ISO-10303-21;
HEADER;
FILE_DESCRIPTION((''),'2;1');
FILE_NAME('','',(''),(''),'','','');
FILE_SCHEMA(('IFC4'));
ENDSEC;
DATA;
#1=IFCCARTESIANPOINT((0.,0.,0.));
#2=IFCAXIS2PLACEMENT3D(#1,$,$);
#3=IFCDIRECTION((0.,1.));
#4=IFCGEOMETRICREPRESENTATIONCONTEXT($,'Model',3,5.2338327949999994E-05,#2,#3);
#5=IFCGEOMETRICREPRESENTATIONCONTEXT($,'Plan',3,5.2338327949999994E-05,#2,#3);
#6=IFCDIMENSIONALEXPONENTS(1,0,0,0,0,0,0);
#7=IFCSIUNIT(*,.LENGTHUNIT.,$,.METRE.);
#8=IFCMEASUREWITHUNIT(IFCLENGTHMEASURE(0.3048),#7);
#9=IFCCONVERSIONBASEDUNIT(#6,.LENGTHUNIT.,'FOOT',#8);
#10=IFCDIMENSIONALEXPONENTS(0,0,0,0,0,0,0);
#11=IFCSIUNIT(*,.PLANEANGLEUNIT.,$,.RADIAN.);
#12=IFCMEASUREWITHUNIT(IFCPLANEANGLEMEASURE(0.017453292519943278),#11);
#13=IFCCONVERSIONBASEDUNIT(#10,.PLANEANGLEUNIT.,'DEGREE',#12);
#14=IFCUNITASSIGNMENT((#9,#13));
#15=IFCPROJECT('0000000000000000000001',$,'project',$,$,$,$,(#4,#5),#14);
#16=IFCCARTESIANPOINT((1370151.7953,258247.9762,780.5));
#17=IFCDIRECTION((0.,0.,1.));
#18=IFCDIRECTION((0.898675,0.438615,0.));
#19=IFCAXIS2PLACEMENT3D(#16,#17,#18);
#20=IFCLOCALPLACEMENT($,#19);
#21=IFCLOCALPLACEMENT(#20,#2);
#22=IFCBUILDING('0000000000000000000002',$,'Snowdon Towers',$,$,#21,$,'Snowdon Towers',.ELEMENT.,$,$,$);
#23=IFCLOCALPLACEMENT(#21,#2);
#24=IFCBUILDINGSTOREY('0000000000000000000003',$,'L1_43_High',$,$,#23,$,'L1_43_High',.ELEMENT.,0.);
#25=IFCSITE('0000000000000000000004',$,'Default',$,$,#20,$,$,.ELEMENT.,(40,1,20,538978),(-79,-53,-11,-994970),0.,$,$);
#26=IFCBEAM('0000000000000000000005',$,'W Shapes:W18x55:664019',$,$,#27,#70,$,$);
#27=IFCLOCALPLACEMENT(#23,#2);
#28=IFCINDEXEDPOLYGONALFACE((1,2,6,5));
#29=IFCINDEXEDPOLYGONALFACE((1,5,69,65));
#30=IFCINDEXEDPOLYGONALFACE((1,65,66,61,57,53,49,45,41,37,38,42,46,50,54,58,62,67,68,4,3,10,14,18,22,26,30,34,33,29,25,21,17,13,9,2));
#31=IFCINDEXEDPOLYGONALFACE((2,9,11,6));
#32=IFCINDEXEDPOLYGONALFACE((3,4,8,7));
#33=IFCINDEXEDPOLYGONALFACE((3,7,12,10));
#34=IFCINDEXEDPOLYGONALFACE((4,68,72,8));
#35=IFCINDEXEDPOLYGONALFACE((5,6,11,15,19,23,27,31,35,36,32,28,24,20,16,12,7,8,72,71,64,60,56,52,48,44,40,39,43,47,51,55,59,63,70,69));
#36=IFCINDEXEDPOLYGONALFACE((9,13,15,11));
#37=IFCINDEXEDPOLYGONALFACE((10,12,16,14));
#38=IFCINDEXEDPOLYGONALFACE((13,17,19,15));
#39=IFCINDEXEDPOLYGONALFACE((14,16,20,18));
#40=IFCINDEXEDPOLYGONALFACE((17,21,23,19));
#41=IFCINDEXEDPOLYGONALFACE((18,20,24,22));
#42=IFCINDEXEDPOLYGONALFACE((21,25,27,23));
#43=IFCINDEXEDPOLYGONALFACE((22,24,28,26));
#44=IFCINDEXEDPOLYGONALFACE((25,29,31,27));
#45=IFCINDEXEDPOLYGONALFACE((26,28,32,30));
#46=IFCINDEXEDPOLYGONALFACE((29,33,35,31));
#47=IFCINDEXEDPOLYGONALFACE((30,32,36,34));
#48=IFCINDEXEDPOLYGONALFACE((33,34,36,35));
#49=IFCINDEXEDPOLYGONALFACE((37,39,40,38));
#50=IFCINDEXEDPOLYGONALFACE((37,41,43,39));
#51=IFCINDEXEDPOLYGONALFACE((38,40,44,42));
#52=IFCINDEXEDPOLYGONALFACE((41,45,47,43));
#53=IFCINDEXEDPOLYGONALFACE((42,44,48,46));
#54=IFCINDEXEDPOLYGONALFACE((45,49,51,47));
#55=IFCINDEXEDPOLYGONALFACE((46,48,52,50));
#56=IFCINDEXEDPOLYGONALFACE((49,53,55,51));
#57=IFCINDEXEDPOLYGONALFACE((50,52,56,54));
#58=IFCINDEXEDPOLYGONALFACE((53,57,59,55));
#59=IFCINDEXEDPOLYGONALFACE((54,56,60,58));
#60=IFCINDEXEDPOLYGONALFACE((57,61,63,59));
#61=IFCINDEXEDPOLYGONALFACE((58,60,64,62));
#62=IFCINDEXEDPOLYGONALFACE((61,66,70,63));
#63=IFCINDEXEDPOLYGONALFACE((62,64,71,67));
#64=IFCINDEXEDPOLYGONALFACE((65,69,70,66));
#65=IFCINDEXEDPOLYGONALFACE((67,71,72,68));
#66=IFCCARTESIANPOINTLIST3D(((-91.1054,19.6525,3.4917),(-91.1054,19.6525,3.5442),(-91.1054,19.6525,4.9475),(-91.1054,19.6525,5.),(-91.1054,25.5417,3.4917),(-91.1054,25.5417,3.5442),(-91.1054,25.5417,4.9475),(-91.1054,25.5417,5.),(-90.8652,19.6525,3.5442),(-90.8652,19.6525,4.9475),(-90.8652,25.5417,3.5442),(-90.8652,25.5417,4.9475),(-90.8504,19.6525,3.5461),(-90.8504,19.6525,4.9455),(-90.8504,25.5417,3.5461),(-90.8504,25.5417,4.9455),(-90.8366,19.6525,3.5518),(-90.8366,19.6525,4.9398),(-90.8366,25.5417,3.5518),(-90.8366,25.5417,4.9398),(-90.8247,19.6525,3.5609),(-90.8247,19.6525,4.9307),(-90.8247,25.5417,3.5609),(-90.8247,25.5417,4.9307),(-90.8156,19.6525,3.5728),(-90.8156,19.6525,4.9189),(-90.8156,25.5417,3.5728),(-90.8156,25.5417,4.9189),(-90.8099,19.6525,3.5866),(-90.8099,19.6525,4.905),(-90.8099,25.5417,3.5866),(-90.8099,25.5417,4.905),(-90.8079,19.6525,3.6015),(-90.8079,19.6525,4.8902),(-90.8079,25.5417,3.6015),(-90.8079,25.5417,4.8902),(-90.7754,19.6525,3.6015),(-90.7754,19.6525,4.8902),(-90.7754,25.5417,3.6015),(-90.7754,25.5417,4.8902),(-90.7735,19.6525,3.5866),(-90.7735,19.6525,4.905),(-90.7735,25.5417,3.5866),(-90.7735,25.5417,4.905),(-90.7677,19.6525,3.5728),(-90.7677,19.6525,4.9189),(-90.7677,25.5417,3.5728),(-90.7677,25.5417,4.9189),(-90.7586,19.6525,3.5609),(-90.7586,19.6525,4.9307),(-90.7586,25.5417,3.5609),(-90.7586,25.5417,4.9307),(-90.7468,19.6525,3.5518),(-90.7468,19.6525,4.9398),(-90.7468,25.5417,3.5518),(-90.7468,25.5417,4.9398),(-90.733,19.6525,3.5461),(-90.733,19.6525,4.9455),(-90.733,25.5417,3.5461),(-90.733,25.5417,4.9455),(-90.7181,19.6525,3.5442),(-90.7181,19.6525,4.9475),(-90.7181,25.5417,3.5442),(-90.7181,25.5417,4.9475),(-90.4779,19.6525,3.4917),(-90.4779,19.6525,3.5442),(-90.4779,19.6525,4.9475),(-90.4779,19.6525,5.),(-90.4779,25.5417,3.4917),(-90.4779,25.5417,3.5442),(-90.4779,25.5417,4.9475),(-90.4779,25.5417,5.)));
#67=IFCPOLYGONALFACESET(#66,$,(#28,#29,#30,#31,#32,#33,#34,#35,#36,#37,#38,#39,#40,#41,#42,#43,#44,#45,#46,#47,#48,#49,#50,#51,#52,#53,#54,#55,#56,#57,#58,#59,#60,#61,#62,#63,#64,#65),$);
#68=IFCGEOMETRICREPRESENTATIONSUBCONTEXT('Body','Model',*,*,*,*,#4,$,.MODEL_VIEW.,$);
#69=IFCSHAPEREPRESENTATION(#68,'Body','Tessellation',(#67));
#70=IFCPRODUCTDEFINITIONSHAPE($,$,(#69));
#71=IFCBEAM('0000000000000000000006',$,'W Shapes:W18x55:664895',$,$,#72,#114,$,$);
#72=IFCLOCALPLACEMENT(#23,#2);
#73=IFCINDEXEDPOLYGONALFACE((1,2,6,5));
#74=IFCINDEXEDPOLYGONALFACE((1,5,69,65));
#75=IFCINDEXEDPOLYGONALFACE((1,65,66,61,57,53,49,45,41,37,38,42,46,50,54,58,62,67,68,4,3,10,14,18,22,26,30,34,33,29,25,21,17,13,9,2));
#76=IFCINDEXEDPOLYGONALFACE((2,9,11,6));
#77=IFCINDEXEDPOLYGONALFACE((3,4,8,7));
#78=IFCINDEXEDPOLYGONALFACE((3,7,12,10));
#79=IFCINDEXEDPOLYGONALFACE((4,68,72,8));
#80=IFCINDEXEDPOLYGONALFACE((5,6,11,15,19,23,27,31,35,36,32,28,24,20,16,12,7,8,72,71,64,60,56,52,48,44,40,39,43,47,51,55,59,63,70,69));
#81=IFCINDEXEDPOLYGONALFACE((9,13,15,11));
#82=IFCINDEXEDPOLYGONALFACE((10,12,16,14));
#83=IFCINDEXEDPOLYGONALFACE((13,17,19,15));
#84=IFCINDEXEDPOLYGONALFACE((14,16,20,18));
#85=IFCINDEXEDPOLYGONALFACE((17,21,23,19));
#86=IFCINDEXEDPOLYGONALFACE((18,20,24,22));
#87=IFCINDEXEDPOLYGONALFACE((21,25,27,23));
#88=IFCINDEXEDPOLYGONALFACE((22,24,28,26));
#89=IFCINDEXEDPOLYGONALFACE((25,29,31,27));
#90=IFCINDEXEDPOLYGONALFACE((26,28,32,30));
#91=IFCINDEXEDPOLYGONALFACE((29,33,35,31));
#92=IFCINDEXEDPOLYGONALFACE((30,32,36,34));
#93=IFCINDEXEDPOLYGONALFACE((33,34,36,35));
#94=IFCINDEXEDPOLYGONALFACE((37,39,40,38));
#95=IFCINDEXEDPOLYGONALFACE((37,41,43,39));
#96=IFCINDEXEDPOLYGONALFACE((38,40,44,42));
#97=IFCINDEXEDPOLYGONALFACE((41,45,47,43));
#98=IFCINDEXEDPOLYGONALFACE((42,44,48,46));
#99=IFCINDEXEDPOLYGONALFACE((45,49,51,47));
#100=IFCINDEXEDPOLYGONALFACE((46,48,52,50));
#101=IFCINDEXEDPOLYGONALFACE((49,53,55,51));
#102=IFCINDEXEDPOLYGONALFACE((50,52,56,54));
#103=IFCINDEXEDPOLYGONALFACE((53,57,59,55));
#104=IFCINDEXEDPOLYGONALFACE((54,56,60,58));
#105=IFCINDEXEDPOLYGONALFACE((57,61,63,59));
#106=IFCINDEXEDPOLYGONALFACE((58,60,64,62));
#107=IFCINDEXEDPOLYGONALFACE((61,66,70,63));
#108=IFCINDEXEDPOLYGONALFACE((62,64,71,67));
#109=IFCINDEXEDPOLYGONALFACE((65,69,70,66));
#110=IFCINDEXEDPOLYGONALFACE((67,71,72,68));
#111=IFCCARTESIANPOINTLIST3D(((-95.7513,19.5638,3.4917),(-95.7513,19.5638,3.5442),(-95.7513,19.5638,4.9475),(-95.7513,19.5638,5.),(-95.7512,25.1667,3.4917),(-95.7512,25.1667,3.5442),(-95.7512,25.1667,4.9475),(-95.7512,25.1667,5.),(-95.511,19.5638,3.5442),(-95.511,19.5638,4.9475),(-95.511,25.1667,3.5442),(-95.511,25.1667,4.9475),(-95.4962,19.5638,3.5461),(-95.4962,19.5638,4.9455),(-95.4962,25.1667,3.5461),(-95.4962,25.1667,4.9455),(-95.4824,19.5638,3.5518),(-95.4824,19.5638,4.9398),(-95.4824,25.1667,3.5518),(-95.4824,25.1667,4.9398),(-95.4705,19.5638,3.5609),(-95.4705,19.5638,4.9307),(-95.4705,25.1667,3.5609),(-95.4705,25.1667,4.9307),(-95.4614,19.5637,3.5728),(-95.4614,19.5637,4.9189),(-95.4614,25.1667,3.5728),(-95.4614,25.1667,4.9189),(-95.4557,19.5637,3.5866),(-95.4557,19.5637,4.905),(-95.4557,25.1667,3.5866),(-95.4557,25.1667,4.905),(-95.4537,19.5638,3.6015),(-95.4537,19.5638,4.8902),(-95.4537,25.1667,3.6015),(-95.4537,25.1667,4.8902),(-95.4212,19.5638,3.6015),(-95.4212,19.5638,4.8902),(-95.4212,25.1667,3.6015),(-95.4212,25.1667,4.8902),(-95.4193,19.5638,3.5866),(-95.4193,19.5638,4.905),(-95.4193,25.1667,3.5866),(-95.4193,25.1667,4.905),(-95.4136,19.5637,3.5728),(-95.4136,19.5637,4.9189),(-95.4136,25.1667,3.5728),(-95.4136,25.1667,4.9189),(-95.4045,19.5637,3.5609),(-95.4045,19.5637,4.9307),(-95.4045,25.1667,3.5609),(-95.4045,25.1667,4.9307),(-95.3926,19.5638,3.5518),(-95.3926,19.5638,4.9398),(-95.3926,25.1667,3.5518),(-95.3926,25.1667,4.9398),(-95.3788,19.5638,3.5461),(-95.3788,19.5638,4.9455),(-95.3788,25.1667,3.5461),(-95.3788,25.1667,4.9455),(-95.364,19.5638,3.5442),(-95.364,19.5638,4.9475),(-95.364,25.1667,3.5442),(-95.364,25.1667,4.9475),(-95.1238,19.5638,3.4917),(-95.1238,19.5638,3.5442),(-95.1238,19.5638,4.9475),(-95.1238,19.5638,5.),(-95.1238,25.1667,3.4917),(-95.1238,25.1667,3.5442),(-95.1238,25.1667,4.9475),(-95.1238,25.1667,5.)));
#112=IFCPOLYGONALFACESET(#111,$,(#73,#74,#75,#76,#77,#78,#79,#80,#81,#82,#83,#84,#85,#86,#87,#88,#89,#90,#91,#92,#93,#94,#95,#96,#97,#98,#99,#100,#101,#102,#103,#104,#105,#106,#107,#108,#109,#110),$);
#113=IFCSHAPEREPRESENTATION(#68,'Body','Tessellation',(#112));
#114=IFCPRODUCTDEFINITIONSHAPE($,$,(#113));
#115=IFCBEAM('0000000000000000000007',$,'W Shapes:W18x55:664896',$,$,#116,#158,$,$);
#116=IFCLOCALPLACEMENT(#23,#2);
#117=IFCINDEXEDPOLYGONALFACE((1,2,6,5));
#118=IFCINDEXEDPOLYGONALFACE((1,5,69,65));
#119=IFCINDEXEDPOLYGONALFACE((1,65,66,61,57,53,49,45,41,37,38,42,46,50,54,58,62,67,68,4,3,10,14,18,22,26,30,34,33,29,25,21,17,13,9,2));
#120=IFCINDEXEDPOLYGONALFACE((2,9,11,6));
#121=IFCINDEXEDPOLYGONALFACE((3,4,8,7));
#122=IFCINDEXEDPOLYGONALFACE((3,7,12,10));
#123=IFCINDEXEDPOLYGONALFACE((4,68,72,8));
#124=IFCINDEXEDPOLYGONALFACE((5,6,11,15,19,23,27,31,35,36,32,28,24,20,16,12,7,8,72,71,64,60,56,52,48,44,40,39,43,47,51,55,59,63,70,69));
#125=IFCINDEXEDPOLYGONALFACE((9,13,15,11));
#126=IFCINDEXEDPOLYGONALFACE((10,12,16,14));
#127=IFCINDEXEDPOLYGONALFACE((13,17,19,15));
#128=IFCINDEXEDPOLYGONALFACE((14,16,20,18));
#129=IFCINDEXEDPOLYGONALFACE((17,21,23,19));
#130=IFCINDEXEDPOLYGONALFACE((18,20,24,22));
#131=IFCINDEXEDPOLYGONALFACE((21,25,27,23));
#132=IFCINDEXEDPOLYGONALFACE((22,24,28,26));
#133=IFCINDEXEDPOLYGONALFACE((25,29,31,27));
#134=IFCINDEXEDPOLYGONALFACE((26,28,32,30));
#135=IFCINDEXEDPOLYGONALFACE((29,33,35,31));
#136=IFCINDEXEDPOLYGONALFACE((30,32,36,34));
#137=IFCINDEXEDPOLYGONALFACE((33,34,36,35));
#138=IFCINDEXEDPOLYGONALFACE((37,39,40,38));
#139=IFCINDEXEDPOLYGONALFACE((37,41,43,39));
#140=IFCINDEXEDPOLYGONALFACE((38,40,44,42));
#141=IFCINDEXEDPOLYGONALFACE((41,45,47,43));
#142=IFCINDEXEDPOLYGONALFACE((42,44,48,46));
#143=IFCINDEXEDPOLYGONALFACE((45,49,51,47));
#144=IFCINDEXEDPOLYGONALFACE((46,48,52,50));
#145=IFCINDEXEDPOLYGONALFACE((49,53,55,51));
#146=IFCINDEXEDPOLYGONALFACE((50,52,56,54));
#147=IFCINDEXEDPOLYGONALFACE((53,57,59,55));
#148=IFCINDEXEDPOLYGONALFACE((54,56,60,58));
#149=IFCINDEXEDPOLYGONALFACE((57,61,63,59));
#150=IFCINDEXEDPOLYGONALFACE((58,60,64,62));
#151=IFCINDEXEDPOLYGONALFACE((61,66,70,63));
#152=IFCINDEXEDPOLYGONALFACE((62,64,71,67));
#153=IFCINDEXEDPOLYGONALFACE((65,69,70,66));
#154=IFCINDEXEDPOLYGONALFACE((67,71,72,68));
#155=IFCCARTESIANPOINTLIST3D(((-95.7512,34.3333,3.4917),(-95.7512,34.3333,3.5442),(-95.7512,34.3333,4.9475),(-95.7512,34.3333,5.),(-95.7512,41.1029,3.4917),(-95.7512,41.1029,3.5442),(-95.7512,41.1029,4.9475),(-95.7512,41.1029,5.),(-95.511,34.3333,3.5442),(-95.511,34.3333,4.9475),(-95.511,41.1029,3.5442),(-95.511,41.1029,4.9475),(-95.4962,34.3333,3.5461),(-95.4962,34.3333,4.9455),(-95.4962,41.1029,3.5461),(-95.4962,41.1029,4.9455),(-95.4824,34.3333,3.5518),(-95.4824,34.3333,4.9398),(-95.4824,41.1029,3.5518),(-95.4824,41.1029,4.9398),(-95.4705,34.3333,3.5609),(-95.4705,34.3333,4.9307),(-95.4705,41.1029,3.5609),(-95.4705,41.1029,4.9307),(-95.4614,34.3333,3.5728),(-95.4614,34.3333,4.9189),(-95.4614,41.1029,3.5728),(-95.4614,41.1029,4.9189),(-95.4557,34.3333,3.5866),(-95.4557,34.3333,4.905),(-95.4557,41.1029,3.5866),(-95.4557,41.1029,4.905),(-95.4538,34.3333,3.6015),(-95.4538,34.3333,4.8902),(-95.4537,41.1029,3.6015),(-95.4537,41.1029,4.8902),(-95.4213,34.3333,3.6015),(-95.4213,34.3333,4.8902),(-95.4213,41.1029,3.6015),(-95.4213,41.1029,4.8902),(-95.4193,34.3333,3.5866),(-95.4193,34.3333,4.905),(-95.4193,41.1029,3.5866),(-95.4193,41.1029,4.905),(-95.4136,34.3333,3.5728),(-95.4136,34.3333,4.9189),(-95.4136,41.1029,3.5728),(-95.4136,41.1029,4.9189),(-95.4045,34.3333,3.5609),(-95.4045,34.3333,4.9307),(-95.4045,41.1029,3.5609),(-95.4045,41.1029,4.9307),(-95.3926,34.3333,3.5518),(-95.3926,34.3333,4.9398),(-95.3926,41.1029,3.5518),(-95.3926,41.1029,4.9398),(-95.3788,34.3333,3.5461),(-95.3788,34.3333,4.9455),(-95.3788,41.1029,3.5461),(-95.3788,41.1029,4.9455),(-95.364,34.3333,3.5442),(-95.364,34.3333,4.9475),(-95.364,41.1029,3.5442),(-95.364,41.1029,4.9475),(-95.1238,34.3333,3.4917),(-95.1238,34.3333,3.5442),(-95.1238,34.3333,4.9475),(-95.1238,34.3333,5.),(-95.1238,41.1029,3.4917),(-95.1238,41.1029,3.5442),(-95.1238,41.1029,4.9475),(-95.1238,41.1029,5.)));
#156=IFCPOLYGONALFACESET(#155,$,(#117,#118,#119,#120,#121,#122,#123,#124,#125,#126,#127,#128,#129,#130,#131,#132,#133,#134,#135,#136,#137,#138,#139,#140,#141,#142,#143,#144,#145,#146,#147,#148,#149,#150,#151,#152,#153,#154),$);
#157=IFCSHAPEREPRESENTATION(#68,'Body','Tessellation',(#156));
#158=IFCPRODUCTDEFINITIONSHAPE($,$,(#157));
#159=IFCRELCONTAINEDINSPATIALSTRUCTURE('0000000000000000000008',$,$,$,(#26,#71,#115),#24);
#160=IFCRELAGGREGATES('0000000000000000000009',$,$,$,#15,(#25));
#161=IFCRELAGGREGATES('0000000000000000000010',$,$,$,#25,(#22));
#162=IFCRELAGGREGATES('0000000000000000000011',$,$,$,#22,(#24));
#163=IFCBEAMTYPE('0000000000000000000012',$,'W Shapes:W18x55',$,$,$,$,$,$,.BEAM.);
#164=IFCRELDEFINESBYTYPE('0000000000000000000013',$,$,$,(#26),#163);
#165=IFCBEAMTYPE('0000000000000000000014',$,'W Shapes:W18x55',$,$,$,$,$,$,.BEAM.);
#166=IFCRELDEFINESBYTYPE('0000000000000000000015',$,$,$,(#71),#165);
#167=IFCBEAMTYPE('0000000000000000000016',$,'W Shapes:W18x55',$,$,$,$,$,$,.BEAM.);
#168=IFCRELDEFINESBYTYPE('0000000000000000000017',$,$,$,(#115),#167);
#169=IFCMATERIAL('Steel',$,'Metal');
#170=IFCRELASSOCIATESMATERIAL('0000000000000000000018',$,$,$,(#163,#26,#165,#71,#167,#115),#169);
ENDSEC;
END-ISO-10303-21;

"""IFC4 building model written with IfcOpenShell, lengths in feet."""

from ifc_helpers import new_model, entity, si_unit, converted_unit, direction, frame, origin, place, context, subcontext, project, spatial, line, arc, indexed_curve, outline, extrude, source, transform, mapped, material, type_object, type_shapes, element, save


model = new_model("IFC4")

# Units and contexts
model_context = context("Model", 3, precision=5.2338327949999994e-05, world=origin(), true_north=direction((0.0, 1.0)))
plan_context = context("Plan", 3, precision=5.2338327949999994e-05, world=origin(), true_north=direction((0.0, 1.0)))
body_context = subcontext(model_context, "Body", "Model", "MODEL_VIEW")
ifc_project = project(units=[converted_unit("LENGTHUNIT", "FOOT", entity("IfcLengthMeasure", 0.3048), si_unit("LENGTHUNIT", "METRE"), dimensions=[1, 0, 0, 0, 0, 0, 0]), converted_unit("PLANEANGLEUNIT", "DEGREE", entity("IfcPlaneAngleMeasure", 0.017453292519943278), si_unit("PLANEANGLEUNIT", "RADIAN"), dimensions=[0, 0, 0, 0, 0, 0, 0])], contexts=[model_context, plan_context])

# Site, building, storey
site_placement = place(None, frame((1370151.7953, 258247.9762, 780.5), z_axis=(0.0, 0.0, 1.0), x_axis=(0.898675, 0.438615, 0.0)))
site = spatial("IfcSite", under=ifc_project, at=site_placement, Name="Default", CompositionType="ELEMENT", RefLatitude=(40, 1, 20, 538978), RefLongitude=(-79, -53, -11, -994970), RefElevation=0.0)
building_placement = place(site_placement, origin())
building = spatial("IfcBuilding", under=site, at=building_placement, Name="Snowdon Towers", LongName="Snowdon Towers", CompositionType="ELEMENT")
storey_placement = place(building_placement, origin())
storey = spatial("IfcBuildingStorey", under=building, at=storey_placement, Name="L1_43_High", LongName="L1_43_High", CompositionType="ELEMENT", Elevation=0.0)

# Shared definitions
ifc_material_1 = material(Name="Steel", Category="Metal")

# Beams
beam_type_1 = type_object("IfcBeamType", Name="W Shapes:W18x55", PredefinedType="BEAM", material=ifc_material_1)
shared_shape_1 = source(origin(), body_context, "Body", "SweptSolid", [
    extrude(outline(indexed_curve([(-0.7542, -0.3138), (-0.7017, -0.3138), (-0.7017, -0.0735), (-0.6849, -0.033), (-0.6444, -0.0162), (0.6444, -0.0162), (0.6849, -0.033), (0.7017, -0.0735), (0.7017, -0.3138), (0.7542, -0.3138), (0.7542, 0.3138), (0.7017, 0.3138), (0.7017, 0.0735), (0.6849, 0.033), (0.6444, 0.0163), (-0.6444, 0.0163), (-0.6849, 0.033), (-0.7017, 0.0735), (-0.7017, 0.3137), (-0.7542, 0.3137)], segments=[line(1, 2, 3), arc(3, 4, 5), line(5, 6), arc(6, 7, 8), line(8, 9, 10, 11, 12, 13), arc(13, 14, 15), line(15, 16), arc(16, 17, 18), line(18, 19, 20, 1)], self_intersect=False)), frame((-2.7154, 0.0, 0.0), z_axis=(1.0, 0.0, 0.0), x_axis=(0.0, 0.0, -1.0)), (0.0, 0.0, 1.0), 5.8892),
])
type_shapes(beam_type_1, [shared_shape_1])
beam_1_placement = place(storey_placement, frame((-90.7917, 22.3679, 4.2458), z_axis=(0.0, 0.0, 1.0), x_axis=(0.0, 1.0, 0.0)))
element("IfcBeam", 1, at=beam_1_placement, inside=storey, type_object=beam_type_1, material=ifc_material_1, Name="W Shapes:W18x55:664019", context=body_context, shape_type="MappedRepresentation", body=[
    mapped(shared_shape_1, transform((0.0, 0.0, 0.0), scale=1.0)),
])
beam_type_2 = type_object("IfcBeamType", Name="W Shapes:W18x55", PredefinedType="BEAM", material=ifc_material_1)
shared_shape_2 = source(origin(), body_context, "Body", "SweptSolid", [
    extrude(outline(indexed_curve([(-0.7542, -0.3138), (-0.7017, -0.3138), (-0.7017, -0.0735), (-0.6849, -0.033), (-0.6444, -0.0162), (0.6444, -0.0162), (0.6849, -0.033), (0.7017, -0.0735), (0.7017, -0.3138), (0.7542, -0.3138), (0.7542, 0.3138), (0.7017, 0.3138), (0.7017, 0.0735), (0.6849, 0.033), (0.6444, 0.0163), (-0.6444, 0.0163), (-0.6849, 0.033), (-0.7017, 0.0735), (-0.7017, 0.3137), (-0.7542, 0.3137)], segments=[line(1, 2, 3), arc(3, 4, 5), line(5, 6), arc(6, 7, 8), line(8, 9, 10, 11, 12, 13), arc(13, 14, 15), line(15, 16), arc(16, 17, 18), line(18, 19, 20, 1)], self_intersect=False)), frame((-2.8529, 0.0, 0.0), z_axis=(1.0, 0.0, 0.0), x_axis=(0.0, 0.0, -1.0)), (0.0, 0.0, 1.0), 5.6029),
])
type_shapes(beam_type_2, [shared_shape_2])
beam_2_placement = place(storey_placement, frame((-95.4375, 22.4167, 4.2458), z_axis=(0.0, 0.0, 1.0), x_axis=(0.0, 1.0, 0.0)))
element("IfcBeam", 2, at=beam_2_placement, inside=storey, type_object=beam_type_2, material=ifc_material_1, Name="W Shapes:W18x55:664895", context=body_context, shape_type="MappedRepresentation", body=[
    mapped(shared_shape_2, transform((0.0, 0.0, 0.0), scale=1.0)),
])
beam_type_3 = type_object("IfcBeamType", Name="W Shapes:W18x55", PredefinedType="BEAM", material=ifc_material_1)
shared_shape_3 = source(origin(), body_context, "Body", "SweptSolid", [
    extrude(outline(indexed_curve([(-0.7542, -0.3138), (-0.7017, -0.3138), (-0.7017, -0.0735), (-0.6849, -0.033), (-0.6444, -0.0162), (0.6444, -0.0162), (0.6849, -0.033), (0.7017, -0.0735), (0.7017, -0.3138), (0.7542, -0.3138), (0.7542, 0.3138), (0.7017, 0.3138), (0.7017, 0.0735), (0.6849, 0.033), (0.6444, 0.0163), (-0.6444, 0.0163), (-0.6849, 0.033), (-0.7017, 0.0735), (-0.7017, 0.3137), (-0.7542, 0.3137)], segments=[line(1, 2, 3), arc(3, 4, 5), line(5, 6), arc(6, 7, 8), line(8, 9, 10, 11, 12, 13), arc(13, 14, 15), line(15, 16), arc(16, 17, 18), line(18, 19, 20, 1)], self_intersect=False)), frame((-3.4363, 0.0, 0.0), z_axis=(1.0, 0.0, 0.0), x_axis=(0.0, 0.0, -1.0)), (0.0, 0.0, 1.0), 6.7696),
])
type_shapes(beam_type_3, [shared_shape_3])
beam_3_placement = place(storey_placement, frame((-95.4375, 37.6667, 4.2458), z_axis=(0.0, 0.0, 1.0), x_axis=(0.0, -1.0, 0.0)))
element("IfcBeam", 3, at=beam_3_placement, inside=storey, type_object=beam_type_3, material=ifc_material_1, Name="W Shapes:W18x55:664896", context=body_context, shape_type="MappedRepresentation", body=[
    mapped(shared_shape_3, transform((0.0, 0.0, 0.0), scale=1.0)),
])

save(model, "model.ifc")
